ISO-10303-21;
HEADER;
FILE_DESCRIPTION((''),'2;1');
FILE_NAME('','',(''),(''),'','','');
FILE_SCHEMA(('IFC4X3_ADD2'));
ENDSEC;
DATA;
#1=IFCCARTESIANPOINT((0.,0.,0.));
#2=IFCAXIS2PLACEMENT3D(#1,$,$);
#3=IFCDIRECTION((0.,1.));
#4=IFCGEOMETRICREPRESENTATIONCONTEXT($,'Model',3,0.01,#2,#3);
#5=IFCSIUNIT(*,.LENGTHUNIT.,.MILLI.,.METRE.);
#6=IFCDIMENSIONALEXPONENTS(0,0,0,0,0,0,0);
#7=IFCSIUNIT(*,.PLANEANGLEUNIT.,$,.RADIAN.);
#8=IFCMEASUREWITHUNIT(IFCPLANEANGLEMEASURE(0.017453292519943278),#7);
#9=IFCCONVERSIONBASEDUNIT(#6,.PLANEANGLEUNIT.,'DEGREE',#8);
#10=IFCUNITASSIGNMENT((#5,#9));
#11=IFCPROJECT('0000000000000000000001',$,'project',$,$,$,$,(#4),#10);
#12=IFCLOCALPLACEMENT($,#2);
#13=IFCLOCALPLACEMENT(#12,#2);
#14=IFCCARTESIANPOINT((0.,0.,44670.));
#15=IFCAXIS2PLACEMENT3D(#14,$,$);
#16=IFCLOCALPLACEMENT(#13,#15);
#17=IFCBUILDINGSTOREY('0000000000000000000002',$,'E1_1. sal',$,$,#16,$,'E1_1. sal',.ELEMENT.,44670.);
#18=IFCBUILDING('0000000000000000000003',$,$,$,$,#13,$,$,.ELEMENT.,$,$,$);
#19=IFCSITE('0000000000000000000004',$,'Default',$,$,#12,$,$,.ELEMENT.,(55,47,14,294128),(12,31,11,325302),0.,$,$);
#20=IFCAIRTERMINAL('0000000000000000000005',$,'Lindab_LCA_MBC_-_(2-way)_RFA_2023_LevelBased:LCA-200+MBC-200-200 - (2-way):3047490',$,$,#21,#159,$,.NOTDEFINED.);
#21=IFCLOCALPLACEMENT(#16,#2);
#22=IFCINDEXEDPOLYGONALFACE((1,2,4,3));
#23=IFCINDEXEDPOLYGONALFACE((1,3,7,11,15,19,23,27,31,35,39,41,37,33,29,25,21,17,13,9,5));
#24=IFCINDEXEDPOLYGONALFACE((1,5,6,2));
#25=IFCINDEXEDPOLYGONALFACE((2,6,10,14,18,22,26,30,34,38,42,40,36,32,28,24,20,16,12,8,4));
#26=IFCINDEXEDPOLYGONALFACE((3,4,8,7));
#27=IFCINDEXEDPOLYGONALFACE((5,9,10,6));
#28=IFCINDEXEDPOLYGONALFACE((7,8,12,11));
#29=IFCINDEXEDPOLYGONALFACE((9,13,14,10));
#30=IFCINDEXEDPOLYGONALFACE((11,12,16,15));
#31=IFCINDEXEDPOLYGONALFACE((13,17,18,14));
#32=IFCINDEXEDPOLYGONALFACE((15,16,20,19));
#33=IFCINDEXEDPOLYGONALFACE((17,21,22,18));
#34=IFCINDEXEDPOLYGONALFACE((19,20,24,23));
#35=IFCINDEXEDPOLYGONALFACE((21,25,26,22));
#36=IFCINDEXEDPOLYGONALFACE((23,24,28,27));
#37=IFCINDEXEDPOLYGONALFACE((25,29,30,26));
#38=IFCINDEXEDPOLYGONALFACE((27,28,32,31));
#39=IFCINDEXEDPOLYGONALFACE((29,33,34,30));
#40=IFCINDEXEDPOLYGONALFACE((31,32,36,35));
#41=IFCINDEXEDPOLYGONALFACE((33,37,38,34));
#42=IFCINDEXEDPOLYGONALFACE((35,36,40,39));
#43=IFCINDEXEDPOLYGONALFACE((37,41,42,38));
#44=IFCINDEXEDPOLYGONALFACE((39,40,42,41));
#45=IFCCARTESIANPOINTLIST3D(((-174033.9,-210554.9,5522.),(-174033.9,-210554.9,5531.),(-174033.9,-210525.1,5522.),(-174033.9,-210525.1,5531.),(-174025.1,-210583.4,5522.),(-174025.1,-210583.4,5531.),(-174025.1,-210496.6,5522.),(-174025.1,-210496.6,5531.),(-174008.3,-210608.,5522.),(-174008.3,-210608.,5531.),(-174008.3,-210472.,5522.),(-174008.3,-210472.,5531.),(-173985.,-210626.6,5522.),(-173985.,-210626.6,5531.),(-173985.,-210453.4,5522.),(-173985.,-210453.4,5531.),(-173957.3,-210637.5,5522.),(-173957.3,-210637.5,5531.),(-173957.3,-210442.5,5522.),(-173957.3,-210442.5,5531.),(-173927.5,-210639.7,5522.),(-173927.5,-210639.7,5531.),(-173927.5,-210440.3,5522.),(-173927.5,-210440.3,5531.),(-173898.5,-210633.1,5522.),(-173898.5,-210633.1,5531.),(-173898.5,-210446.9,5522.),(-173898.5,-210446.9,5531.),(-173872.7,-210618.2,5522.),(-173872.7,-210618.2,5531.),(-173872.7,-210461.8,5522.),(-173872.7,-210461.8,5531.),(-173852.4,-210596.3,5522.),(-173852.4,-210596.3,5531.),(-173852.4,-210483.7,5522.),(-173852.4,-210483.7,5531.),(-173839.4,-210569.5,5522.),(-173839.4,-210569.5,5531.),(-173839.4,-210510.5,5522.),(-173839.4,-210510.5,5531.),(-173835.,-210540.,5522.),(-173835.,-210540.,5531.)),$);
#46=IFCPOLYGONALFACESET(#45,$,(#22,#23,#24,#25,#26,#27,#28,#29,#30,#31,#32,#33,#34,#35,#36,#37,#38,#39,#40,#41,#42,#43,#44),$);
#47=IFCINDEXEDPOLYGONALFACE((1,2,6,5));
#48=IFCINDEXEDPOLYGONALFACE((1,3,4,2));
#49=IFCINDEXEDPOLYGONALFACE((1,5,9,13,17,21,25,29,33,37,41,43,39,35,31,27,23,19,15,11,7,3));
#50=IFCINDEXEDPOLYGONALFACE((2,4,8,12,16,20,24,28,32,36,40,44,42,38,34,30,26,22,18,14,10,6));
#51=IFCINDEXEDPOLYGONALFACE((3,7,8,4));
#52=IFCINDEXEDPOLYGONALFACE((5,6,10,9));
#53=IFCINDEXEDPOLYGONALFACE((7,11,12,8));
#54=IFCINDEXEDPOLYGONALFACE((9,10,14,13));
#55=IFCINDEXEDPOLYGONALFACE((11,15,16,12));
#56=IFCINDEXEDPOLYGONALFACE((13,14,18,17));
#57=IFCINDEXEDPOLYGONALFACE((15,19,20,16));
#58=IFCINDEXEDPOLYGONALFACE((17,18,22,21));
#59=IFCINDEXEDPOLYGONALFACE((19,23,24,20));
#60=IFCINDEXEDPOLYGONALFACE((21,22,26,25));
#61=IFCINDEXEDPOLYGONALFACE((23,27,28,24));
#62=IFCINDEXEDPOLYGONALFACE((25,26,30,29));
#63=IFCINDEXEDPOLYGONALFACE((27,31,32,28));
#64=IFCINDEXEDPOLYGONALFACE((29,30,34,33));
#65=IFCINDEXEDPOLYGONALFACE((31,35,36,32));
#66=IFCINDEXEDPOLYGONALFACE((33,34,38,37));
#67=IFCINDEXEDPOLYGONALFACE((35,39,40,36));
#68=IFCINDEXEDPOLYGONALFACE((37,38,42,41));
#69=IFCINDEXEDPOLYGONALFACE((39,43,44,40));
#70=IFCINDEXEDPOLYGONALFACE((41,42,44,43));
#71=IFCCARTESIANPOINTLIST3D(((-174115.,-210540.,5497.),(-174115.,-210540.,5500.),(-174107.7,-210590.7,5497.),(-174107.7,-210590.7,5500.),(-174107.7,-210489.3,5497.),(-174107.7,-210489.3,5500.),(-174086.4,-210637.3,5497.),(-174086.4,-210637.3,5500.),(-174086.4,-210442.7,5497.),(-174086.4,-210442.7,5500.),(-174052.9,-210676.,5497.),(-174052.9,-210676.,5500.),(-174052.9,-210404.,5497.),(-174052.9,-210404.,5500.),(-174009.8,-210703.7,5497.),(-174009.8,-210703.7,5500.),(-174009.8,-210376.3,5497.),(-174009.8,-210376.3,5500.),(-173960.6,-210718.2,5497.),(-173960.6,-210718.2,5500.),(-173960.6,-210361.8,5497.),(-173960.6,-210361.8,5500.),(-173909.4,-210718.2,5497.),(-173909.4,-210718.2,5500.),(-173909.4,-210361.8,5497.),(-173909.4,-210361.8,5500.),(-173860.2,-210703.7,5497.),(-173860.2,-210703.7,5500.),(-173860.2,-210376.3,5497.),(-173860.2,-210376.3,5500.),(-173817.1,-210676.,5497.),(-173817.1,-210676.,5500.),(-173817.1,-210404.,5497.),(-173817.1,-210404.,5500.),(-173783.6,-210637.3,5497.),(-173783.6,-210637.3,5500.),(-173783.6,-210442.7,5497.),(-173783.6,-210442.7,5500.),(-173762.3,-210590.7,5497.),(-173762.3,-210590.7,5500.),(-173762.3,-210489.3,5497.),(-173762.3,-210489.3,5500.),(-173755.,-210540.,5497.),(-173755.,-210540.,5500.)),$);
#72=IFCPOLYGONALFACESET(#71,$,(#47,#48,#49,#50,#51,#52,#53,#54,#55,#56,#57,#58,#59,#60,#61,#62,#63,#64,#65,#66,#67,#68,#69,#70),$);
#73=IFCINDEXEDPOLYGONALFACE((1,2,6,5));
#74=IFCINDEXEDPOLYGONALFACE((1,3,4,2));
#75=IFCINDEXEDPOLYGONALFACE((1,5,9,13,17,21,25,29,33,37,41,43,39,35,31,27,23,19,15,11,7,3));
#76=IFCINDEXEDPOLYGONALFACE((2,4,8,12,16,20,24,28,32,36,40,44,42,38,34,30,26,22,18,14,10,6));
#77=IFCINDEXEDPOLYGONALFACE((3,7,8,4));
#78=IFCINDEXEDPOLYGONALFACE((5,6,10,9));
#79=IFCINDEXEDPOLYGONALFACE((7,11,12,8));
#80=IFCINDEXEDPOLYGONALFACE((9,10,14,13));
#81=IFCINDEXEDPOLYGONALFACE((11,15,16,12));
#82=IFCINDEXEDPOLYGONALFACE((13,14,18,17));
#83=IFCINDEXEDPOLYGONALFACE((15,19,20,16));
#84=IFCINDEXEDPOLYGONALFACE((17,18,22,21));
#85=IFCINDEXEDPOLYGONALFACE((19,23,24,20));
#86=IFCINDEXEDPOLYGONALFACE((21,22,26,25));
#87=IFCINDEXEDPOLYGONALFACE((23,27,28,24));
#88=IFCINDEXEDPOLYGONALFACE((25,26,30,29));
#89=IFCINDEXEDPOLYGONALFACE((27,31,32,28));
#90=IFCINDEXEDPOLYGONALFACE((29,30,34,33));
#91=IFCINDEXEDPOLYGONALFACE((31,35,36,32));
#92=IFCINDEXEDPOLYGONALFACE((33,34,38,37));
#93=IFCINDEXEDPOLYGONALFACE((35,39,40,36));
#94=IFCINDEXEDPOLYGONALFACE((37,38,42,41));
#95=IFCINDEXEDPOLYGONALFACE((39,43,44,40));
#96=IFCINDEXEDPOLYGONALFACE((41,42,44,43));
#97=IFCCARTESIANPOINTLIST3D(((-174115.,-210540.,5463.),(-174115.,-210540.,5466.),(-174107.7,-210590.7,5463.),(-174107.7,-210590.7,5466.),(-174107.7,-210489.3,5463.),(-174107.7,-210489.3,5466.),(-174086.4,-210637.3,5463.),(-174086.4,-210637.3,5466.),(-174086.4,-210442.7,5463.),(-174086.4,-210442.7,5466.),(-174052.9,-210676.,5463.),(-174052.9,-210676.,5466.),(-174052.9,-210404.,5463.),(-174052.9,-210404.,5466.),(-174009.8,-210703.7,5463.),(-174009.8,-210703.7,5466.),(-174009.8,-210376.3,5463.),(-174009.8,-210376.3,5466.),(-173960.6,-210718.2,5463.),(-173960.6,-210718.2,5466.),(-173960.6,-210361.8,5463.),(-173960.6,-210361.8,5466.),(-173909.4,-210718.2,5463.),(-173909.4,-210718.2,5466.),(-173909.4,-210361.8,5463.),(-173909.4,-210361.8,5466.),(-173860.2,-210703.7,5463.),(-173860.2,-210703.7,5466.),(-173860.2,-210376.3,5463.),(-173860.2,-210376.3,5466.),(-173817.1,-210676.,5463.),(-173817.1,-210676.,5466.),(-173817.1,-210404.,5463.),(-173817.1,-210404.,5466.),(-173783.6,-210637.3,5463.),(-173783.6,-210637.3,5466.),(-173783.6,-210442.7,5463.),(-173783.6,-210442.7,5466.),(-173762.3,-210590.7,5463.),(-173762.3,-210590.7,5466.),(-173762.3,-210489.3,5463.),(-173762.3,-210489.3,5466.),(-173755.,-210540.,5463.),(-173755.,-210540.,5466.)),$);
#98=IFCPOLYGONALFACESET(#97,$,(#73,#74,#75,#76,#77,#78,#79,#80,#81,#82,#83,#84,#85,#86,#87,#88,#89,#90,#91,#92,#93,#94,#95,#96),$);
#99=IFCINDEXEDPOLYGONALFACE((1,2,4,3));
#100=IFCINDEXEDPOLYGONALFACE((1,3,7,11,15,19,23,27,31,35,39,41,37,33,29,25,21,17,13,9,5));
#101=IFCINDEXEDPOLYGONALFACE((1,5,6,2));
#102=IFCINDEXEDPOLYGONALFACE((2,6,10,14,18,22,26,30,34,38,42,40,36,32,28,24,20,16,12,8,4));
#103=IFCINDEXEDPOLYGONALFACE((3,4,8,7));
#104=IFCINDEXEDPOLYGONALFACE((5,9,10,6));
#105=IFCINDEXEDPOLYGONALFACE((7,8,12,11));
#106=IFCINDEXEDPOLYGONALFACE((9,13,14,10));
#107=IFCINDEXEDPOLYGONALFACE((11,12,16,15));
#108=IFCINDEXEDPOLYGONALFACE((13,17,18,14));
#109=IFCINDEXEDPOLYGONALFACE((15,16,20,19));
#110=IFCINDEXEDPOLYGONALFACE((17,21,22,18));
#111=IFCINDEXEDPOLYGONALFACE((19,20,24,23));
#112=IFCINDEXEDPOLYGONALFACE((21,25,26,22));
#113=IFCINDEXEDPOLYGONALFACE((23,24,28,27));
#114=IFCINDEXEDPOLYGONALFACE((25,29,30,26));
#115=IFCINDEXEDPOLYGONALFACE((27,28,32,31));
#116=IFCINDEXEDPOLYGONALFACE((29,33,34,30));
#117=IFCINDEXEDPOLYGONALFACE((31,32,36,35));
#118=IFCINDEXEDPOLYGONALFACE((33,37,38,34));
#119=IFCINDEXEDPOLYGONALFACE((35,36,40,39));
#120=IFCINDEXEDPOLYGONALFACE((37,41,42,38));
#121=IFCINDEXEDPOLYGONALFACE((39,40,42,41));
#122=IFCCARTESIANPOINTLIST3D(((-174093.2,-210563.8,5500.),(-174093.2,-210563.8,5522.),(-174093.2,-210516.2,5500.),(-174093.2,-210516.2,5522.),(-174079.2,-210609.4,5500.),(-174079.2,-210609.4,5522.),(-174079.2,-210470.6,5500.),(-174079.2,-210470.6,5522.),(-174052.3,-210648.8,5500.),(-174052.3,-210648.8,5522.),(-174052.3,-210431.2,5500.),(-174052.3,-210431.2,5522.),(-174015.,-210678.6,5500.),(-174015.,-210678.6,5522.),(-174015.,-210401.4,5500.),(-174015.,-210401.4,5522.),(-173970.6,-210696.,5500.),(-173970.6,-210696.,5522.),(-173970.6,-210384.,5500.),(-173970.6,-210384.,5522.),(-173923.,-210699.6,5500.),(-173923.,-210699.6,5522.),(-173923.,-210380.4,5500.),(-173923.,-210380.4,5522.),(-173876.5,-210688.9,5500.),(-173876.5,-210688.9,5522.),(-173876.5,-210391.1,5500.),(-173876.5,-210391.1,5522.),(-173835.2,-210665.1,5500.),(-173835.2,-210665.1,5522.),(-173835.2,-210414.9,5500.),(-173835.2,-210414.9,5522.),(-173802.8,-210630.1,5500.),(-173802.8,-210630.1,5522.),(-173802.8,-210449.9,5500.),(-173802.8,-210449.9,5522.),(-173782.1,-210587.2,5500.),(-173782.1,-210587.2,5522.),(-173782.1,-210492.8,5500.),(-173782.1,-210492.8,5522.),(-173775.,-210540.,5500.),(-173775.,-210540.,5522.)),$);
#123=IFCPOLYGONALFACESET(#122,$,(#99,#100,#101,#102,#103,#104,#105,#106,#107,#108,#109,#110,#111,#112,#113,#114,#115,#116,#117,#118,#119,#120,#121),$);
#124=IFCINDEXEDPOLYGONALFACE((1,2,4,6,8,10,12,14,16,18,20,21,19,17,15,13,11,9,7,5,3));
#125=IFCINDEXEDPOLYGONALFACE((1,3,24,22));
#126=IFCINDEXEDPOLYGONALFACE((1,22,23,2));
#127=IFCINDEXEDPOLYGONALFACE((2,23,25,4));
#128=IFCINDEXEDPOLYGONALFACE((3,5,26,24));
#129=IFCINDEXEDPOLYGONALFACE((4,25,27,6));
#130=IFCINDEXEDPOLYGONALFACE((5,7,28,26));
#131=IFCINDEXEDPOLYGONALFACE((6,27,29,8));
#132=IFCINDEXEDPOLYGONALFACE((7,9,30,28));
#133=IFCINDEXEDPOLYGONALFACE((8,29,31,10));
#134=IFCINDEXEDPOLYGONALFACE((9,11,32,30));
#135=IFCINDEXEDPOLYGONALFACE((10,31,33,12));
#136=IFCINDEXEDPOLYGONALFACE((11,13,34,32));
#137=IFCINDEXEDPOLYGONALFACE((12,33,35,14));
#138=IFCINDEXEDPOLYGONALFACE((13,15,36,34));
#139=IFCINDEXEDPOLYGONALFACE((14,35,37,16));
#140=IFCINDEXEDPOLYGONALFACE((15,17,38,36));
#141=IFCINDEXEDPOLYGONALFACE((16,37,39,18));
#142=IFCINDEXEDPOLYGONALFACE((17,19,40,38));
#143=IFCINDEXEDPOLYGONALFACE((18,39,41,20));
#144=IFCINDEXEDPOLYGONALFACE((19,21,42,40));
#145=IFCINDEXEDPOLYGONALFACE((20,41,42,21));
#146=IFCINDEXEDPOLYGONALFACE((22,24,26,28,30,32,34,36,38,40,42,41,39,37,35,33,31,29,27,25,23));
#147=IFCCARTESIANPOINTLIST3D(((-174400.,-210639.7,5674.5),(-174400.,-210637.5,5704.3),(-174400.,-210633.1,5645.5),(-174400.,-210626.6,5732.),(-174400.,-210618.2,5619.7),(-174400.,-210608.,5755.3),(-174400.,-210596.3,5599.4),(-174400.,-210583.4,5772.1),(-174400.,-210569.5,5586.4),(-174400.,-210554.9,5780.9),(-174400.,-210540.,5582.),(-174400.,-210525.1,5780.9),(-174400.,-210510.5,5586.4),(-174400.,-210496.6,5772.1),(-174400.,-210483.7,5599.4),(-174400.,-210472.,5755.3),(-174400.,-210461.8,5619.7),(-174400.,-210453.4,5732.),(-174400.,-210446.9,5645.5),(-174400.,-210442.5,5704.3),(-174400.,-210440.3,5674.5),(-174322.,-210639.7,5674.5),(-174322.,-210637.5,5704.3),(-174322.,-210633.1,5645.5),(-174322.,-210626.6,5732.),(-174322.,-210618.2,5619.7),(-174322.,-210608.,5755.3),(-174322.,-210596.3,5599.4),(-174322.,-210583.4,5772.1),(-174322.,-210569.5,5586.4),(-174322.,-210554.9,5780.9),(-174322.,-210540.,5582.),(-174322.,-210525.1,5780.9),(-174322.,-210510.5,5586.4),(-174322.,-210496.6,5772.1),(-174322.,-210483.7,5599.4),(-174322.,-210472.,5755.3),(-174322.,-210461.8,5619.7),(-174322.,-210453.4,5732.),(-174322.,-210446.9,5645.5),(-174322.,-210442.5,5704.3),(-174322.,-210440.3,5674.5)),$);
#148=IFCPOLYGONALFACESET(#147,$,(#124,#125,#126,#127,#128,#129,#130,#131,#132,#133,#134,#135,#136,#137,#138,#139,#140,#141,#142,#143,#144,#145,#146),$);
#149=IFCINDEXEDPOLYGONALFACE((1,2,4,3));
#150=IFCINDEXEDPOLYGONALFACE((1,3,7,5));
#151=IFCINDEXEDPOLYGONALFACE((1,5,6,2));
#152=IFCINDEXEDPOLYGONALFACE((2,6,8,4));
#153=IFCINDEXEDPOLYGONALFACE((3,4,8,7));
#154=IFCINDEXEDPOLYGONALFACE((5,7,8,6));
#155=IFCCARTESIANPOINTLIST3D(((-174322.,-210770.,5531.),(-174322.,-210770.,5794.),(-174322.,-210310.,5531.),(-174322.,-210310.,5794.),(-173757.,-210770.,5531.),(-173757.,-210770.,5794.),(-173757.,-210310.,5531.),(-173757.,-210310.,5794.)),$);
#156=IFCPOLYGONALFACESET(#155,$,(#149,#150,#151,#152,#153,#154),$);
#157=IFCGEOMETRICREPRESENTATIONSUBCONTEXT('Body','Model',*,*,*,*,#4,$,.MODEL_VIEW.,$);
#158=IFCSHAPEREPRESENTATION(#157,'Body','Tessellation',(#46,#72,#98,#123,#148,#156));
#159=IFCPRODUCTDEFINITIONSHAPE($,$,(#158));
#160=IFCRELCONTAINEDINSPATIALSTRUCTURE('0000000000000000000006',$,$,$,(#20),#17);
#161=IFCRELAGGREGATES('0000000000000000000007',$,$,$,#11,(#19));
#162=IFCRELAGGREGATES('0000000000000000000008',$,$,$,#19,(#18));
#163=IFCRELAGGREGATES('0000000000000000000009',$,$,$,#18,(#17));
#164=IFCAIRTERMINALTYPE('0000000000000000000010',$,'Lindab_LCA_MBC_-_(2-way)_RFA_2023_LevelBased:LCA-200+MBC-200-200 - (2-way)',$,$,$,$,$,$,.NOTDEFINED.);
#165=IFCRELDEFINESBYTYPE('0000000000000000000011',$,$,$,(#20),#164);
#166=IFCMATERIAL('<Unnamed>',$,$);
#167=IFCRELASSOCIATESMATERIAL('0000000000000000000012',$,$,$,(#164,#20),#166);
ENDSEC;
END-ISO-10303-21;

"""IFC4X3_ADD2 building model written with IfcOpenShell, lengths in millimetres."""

from ifc_helpers import new_model, entity, si_unit, converted_unit, direction, frame, frame_2d, origin, origin_2d_with_axis, place, context, subcontext, project, spatial, rectangle, circle, extrude, source, transform, mapped, material, type_object, type_shapes, element, save


model = new_model("IFC4X3_ADD2")

# Units and contexts
model_context = context("Model", 3, precision=0.01, world=origin(), true_north=direction((0.0, 1.0)))
body_context = subcontext(model_context, "Body", "Model", "MODEL_VIEW")
ifc_project = project(units=[si_unit("LENGTHUNIT", "METRE", prefix="MILLI"), converted_unit("PLANEANGLEUNIT", "DEGREE", entity("IfcPlaneAngleMeasure", 0.017453292519943278), si_unit("PLANEANGLEUNIT", "RADIAN"), dimensions=[0, 0, 0, 0, 0, 0, 0])], contexts=[model_context])

# Site, building, storey
site_placement = place(None, origin())
site = spatial("IfcSite", under=ifc_project, at=site_placement, Name="Default", CompositionType="ELEMENT", RefLatitude=(55, 47, 14, 294128), RefLongitude=(12, 31, 11, 325302), RefElevation=0.0)
building_placement = place(site_placement, origin())
building = spatial("IfcBuilding", under=site, at=building_placement, CompositionType="ELEMENT")
storey_placement = place(building_placement, frame((0.0, 0.0, 44670.0)))
storey = spatial("IfcBuildingStorey", under=building, at=storey_placement, Name="E1_1. sal", LongName="E1_1. sal", CompositionType="ELEMENT", Elevation=44670.0)

# Air terminal
ifc_material_1 = material(Name="<Unnamed>")
air_terminal_type_1 = type_object("IfcAirTerminalType", Name="Lindab_LCA_MBC_-_(2-way)_RFA_2023_LevelBased:LCA-200+MBC-200-200 - (2-way)", PredefinedType="NOTDEFINED", material=ifc_material_1)
shared_shape_1 = source(origin(), body_context, "Body", "SweptSolid", [
    extrude(circle(Radius=100.0, at=frame_2d((0.0, 0.0), x_axis=(1.0, 0.0))), frame((0.0, 0.0, 22.0)), (0.0, 0.0, 1.0), 9.0),
    extrude(circle(Radius=180.0, at=frame_2d((0.0, 0.0), x_axis=(1.0, 0.0))), frame((0.0, 0.0, -3.0)), (0.0, 0.0, 1.0), 3.0),
    extrude(circle(Radius=180.0, at=frame_2d((0.0, 0.0), x_axis=(1.0, 0.0))), frame((0.0, 0.0, -37.0)), (0.0, 0.0, 1.0), 3.0),
    extrude(circle(Radius=160.0, at=frame_2d((0.0, 0.0), x_axis=(1.0, 0.0))), origin(), (0.0, 0.0, 1.0), 22.0),
    extrude(circle(Radius=100.0, at=frame_2d((0.0, 0.0), x_axis=(1.0, 0.0))), frame((-465.0, 0.0, 182.0), z_axis=(1.0, 0.0, 0.0), x_axis=(0.0, 0.0, -1.0)), (0.0, 0.0, 1.0), 78.0),
    extrude(rectangle(XDim=460.0, YDim=565.0, at=origin_2d_with_axis()), frame((-104.5, 0.0, 31.0), z_axis=(0.0, 0.0, 1.0), x_axis=(0.0, -1.0, 0.0)), (0.0, 0.0, 1.0), 263.0),
])
type_shapes(air_terminal_type_1, [shared_shape_1])
for number, where, name in (
    (1, (-173935.0, -210540.0, 5500.0), "Lindab_LCA_MBC_-_(2-way)_RFA_2023_LevelBased:LCA-200+MBC-200-200 - (2-way):3047490"),
):
    element("IfcAirTerminal", number, at=place(storey_placement, frame(where)), inside=storey, type_object=air_terminal_type_1, material=ifc_material_1, Name=name, PredefinedType="NOTDEFINED", context=body_context, shape_type="MappedRepresentation", body=[
        mapped(shared_shape_1, transform((0.0, 0.0, 0.0), scale=1.0)),
    ])

save(model, "model.ifc")
